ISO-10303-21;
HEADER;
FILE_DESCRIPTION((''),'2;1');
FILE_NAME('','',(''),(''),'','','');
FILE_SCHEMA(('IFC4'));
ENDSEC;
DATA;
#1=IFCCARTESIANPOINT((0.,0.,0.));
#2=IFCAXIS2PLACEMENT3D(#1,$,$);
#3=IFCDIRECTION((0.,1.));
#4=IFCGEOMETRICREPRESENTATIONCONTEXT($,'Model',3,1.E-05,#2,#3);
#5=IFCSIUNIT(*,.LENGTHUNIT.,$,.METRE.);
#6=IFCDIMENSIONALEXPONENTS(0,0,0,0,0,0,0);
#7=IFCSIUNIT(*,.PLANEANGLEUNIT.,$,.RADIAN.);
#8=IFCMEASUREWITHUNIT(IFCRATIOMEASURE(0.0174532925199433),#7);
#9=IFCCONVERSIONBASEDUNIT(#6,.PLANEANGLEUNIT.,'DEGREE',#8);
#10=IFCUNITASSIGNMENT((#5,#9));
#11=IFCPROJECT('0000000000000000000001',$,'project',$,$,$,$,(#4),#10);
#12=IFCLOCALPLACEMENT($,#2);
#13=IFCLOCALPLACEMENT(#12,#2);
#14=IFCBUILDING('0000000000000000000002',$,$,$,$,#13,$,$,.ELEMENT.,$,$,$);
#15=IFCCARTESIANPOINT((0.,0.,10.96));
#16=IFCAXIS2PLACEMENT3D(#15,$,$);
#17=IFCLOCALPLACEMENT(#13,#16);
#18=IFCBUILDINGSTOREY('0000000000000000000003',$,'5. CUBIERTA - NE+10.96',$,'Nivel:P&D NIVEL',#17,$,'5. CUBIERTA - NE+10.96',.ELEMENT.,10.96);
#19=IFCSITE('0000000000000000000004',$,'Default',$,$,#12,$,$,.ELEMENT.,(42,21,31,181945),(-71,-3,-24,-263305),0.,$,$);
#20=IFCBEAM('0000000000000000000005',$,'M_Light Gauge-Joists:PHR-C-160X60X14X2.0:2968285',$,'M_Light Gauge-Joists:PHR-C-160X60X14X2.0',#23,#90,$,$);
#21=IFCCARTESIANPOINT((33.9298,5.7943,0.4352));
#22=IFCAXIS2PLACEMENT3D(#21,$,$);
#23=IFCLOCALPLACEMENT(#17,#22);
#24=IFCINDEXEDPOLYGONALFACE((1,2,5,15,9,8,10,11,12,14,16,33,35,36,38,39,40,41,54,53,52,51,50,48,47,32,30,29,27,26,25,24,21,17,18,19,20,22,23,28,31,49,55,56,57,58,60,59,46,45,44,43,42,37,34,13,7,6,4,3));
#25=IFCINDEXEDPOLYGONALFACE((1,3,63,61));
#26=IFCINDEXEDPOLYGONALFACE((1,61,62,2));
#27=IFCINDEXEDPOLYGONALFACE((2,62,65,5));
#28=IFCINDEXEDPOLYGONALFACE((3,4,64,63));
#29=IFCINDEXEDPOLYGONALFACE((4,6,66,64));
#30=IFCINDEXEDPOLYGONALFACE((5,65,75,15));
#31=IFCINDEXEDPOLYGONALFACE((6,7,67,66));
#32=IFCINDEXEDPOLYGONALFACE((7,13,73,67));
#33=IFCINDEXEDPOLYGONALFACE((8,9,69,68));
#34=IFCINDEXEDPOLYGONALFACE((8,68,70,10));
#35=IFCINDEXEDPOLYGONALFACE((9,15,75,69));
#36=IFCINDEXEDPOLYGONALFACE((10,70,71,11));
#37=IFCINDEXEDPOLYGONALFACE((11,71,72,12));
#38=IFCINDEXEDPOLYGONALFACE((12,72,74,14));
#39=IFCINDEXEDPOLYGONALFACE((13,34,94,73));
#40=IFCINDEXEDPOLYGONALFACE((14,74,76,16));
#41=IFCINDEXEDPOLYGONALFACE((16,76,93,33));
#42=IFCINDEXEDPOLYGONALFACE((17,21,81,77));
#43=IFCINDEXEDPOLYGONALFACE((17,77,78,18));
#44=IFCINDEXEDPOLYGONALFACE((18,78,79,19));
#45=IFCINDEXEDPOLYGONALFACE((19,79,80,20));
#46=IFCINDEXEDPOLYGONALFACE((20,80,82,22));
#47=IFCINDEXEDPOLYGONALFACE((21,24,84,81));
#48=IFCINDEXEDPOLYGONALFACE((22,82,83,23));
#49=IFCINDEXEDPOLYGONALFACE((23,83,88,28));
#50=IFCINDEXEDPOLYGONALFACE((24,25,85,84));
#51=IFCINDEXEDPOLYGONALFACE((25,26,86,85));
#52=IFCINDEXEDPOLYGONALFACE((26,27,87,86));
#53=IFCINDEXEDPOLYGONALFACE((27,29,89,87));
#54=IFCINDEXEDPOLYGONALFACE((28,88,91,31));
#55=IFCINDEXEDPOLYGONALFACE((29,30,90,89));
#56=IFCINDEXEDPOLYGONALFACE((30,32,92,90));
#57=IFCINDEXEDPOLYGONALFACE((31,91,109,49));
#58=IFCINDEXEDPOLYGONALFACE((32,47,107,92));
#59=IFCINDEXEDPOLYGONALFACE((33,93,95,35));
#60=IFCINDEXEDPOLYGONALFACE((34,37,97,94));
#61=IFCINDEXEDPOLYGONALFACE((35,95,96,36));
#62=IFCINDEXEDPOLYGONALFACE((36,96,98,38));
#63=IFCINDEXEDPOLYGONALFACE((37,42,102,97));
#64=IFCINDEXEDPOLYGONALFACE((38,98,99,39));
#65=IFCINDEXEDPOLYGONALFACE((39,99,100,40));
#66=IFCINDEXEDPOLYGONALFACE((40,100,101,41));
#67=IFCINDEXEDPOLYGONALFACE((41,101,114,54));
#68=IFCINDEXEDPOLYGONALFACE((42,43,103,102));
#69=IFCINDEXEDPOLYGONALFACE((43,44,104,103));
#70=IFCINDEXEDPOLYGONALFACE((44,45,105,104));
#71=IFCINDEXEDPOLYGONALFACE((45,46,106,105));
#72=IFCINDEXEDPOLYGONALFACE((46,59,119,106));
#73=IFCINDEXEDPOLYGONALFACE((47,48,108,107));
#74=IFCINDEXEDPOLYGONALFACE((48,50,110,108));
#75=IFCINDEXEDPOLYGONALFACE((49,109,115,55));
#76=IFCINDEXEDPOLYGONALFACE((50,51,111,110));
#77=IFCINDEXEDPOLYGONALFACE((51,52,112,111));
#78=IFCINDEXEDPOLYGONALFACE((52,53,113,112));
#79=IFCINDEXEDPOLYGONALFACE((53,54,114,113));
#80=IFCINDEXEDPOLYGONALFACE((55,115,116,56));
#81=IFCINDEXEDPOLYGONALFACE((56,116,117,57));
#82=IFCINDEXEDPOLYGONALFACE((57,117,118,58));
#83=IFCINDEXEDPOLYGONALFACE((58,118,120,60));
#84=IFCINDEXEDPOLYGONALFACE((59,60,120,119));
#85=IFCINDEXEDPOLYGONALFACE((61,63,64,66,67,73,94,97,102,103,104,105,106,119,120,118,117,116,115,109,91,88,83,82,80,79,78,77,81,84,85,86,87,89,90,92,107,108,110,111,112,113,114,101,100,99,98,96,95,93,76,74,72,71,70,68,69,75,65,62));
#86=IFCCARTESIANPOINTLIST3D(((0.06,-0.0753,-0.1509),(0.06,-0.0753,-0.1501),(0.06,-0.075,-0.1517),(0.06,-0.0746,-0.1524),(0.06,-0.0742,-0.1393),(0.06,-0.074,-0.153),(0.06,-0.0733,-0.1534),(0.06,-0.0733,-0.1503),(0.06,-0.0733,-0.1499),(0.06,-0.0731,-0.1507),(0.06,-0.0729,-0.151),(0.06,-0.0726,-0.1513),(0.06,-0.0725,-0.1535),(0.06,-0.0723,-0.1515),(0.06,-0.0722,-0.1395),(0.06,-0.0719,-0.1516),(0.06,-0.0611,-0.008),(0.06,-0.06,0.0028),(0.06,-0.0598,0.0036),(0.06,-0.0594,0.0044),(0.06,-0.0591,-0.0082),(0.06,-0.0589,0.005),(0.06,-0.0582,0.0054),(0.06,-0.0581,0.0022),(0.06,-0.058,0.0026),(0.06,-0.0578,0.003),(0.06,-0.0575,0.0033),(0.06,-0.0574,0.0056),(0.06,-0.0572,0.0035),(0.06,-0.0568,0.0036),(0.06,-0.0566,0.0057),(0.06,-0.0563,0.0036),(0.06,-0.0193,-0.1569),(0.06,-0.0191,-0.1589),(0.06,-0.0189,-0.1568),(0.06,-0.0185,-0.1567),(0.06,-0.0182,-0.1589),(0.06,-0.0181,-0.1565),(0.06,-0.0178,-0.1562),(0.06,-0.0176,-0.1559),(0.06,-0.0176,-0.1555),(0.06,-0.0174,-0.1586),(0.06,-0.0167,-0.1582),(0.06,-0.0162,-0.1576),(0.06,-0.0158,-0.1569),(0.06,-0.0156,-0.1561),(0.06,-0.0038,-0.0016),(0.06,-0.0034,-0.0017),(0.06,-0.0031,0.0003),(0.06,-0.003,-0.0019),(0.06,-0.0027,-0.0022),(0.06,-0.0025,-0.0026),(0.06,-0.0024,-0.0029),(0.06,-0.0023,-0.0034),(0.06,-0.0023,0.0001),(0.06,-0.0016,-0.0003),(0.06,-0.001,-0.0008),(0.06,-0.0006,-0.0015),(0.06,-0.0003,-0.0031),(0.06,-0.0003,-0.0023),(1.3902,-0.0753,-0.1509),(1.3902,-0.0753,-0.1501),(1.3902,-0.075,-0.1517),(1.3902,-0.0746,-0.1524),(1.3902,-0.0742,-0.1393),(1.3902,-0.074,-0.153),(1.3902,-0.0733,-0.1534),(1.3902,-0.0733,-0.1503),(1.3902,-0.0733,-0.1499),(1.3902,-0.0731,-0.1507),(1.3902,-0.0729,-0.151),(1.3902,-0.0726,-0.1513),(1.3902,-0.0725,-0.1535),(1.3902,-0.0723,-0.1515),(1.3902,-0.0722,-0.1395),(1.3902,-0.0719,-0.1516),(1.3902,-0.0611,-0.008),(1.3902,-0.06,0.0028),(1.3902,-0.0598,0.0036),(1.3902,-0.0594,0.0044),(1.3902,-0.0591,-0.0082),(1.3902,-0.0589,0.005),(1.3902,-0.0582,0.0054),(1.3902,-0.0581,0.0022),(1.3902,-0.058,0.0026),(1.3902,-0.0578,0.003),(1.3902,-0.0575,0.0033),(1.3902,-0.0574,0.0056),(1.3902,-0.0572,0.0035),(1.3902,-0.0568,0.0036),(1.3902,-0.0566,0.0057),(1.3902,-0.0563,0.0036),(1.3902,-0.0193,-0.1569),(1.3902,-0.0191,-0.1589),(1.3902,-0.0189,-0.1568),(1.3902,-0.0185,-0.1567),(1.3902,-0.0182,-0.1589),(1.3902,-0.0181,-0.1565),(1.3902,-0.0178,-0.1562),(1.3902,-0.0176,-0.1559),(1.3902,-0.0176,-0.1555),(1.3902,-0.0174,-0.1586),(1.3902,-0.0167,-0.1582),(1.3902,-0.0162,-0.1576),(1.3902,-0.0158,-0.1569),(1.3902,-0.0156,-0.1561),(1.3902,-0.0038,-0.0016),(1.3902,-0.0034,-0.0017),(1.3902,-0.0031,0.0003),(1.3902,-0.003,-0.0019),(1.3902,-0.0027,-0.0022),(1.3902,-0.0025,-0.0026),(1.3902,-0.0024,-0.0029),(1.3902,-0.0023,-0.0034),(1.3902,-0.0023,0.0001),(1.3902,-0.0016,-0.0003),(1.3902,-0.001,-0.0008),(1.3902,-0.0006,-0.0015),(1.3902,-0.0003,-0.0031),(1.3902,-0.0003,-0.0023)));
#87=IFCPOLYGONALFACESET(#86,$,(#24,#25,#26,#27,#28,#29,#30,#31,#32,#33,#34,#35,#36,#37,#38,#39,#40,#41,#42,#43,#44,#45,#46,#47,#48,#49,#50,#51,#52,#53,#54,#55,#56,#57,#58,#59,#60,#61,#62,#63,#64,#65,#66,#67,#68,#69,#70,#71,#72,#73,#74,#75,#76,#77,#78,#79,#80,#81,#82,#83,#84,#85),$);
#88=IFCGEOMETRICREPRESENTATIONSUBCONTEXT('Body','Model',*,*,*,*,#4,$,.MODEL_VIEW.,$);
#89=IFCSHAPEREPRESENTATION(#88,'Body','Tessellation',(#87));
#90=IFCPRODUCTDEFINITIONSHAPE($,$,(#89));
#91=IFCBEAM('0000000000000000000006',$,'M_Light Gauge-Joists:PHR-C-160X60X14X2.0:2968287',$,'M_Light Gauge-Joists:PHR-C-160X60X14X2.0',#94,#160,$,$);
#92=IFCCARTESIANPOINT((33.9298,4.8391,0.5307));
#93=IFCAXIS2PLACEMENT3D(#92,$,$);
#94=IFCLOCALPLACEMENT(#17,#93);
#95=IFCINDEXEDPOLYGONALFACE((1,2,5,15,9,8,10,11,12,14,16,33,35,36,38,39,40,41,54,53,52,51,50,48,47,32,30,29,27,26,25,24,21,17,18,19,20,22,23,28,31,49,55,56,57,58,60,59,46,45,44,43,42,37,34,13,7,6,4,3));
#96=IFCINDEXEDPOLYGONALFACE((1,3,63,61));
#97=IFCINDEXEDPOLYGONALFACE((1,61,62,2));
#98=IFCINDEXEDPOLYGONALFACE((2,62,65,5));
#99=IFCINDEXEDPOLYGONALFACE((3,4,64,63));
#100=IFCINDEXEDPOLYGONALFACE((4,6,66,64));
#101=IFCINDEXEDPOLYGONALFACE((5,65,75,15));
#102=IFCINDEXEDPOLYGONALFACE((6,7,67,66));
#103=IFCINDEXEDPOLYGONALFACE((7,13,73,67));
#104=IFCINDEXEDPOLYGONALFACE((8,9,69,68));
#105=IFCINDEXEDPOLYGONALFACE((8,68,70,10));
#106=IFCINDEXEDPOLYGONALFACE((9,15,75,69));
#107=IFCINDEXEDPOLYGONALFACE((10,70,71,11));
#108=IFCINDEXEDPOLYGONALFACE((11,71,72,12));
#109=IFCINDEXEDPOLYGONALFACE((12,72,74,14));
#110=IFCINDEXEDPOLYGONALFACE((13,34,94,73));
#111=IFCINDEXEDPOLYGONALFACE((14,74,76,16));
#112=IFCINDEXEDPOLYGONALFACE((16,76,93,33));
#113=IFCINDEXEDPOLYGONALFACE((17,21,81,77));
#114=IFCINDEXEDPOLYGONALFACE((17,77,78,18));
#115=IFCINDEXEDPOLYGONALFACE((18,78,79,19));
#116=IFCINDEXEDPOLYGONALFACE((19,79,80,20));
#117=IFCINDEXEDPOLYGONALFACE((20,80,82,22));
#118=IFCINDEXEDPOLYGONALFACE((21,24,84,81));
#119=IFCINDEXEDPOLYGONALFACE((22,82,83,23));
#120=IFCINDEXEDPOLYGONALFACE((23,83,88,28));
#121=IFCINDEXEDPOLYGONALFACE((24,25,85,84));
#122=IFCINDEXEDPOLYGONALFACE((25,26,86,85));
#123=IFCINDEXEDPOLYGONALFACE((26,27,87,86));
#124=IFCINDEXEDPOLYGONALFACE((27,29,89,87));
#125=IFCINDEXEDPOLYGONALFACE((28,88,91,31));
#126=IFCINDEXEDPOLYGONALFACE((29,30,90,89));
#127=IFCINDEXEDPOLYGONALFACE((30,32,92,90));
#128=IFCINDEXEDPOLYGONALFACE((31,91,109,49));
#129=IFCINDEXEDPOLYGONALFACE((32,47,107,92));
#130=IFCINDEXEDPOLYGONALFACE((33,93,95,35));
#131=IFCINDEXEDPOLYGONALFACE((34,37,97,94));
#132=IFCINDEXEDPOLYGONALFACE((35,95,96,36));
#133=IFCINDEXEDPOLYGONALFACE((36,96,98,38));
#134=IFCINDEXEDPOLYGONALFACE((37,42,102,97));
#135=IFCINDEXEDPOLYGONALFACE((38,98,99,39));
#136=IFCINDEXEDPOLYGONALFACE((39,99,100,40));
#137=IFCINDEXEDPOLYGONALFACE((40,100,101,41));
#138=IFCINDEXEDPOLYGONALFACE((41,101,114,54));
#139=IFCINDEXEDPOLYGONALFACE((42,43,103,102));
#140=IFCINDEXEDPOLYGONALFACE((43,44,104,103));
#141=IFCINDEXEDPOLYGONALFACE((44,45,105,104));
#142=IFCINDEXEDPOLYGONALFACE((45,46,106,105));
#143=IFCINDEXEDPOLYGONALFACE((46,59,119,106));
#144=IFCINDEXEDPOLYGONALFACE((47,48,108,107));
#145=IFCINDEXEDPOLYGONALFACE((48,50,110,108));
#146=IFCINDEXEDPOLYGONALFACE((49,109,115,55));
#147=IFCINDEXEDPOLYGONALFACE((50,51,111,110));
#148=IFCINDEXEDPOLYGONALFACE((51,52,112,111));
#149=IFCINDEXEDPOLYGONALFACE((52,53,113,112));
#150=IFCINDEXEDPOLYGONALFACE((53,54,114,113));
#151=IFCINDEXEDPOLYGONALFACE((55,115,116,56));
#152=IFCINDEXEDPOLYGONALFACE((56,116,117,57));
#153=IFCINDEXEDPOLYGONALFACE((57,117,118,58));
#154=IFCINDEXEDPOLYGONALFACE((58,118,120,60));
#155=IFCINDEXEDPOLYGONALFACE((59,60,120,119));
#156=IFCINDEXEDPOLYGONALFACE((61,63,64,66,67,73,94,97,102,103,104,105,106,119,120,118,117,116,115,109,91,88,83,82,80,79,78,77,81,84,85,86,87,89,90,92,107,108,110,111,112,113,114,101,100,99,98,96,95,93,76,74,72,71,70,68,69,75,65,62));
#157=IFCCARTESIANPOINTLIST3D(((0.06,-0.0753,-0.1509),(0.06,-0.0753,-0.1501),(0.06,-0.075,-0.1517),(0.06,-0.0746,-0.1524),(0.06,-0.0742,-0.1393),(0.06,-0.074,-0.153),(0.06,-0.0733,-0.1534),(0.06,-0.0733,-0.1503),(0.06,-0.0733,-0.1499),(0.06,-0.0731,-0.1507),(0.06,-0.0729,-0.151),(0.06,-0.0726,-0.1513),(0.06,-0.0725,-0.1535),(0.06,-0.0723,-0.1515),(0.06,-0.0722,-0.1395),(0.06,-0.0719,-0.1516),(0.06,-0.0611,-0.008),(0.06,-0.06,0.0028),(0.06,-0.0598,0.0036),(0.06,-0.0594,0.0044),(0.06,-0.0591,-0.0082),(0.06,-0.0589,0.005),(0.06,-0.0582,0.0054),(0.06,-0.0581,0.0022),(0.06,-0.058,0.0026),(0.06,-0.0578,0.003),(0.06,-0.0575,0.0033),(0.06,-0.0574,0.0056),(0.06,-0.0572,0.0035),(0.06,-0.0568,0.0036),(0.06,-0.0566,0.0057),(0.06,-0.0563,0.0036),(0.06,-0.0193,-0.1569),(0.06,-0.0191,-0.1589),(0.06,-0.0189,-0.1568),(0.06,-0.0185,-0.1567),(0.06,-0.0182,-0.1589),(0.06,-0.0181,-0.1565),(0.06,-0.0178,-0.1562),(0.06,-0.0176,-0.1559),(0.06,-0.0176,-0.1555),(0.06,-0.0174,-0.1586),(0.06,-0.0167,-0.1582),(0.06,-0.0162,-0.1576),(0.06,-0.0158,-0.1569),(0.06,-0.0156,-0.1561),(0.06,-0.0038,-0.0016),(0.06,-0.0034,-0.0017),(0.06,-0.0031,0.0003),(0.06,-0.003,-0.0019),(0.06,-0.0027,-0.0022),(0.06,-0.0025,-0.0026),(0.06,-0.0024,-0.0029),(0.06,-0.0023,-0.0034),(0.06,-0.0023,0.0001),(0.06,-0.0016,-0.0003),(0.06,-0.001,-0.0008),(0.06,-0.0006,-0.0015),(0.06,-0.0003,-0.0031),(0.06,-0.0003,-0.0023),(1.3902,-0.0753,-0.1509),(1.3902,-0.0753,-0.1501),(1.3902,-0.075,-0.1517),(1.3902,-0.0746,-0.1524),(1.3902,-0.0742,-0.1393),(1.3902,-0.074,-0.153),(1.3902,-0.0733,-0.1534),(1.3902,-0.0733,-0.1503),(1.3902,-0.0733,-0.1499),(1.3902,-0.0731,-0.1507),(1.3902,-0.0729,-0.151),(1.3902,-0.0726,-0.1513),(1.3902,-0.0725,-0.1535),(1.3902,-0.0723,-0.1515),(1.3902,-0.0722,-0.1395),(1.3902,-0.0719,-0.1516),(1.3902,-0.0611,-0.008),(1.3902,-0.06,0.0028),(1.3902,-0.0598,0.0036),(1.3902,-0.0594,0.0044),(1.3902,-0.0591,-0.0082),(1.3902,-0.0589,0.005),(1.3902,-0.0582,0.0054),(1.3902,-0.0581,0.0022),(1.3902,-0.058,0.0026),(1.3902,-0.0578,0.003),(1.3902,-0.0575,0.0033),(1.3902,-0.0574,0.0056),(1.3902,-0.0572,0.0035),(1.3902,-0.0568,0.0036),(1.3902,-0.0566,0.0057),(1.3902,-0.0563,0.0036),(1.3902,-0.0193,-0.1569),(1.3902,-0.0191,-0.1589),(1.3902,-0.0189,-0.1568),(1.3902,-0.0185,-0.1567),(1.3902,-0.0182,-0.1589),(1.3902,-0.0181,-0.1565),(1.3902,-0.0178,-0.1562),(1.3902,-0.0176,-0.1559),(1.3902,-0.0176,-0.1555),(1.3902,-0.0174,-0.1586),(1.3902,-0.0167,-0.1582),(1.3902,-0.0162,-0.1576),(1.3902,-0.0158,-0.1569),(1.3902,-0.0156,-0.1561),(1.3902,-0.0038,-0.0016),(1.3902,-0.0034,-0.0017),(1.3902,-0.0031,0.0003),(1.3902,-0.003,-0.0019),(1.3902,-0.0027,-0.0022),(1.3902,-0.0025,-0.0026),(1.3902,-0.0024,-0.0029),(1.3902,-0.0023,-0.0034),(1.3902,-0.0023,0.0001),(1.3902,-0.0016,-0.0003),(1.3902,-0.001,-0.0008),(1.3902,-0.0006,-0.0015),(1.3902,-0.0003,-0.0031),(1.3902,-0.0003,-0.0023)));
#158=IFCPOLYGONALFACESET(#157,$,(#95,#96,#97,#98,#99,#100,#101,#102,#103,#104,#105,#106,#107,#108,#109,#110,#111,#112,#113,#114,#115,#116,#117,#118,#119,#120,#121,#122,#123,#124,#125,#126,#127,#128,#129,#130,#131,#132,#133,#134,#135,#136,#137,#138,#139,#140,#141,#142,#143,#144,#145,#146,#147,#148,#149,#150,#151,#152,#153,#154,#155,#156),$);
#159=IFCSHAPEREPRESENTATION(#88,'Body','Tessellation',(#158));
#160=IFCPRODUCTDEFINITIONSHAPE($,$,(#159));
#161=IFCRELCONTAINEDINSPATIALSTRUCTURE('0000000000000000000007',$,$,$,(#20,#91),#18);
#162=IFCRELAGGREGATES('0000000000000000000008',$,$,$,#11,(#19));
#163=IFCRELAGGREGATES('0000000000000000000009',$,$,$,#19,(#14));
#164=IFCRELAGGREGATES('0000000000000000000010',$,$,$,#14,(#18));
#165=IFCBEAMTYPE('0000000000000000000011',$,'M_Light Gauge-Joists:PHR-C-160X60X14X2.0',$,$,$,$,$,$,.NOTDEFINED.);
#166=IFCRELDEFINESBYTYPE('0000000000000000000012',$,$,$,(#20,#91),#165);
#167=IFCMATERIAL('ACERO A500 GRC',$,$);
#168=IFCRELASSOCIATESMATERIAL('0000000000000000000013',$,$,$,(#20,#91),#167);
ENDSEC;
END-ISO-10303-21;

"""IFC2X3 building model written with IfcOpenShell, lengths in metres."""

from ifc_helpers import new_model, entity, si_unit, converted_unit, direction, frame, frame_2d, origin, place, context, subcontext, project, spatial, polyline, circle_curve, parameter, trimmed, segment, composite_curve, outline, extrude, material, type_object, element, save


model = new_model("IFC2X3")

# Units and contexts
model_context = context("Model", 3, precision=1e-05, world=origin(), true_north=direction((0.0, 1.0)))
body_context = subcontext(model_context, "Body", "Model", "MODEL_VIEW")
ifc_project = project(units=[si_unit("LENGTHUNIT", "METRE"), converted_unit("PLANEANGLEUNIT", "DEGREE", entity("IfcRatioMeasure", 0.0174532925199433), si_unit("PLANEANGLEUNIT", "RADIAN"), dimensions=[0, 0, 0, 0, 0, 0, 0])], contexts=[model_context])

# Site, building, storey
site_placement = place(None, origin())
site = spatial("IfcSite", under=ifc_project, at=site_placement, Name="Default", CompositionType="ELEMENT", RefLatitude=(42, 21, 31, 181945), RefLongitude=(-71, -3, -24, -263305), RefElevation=0.0)
building_placement = place(site_placement, origin())
building = spatial("IfcBuilding", under=site, at=building_placement, CompositionType="ELEMENT")
storey_placement = place(building_placement, frame((0.0, 0.0, 10.96)))
storey = spatial("IfcBuildingStorey", under=building, at=storey_placement, Name="5. CUBIERTA - NE+10.96", ObjectType="Nivel:P&D NIVEL", LongName="5. CUBIERTA - NE+10.96", CompositionType="ELEMENT", Elevation=10.96)

# Beams
ifc_material_1 = material(Name="ACERO A500 GRC")
beam_type_1 = type_object("IfcBeamType", Name="M_Light Gauge-Joists:PHR-C-160X60X14X2.0", PredefinedType="NOTDEFINED")
beam_1_placement = place(storey_placement, frame((33.9298, 5.7943, 0.4352)))
element("IfcBeam", 1, at=beam_1_placement, inside=storey, type_object=beam_type_1, material=ifc_material_1, Name="M_Light Gauge-Joists:PHR-C-160X60X14X2.0:2968285", ObjectType="M_Light Gauge-Joists:PHR-C-160X60X14X2.0", context=body_context, shape_type="SweptSolid", body=[
    extrude(outline(composite_curve([segment(polyline([(-0.0768, -0.0358), (0.0768, -0.0358)]), True, "CONTINUOUS"), segment(trimmed(circle_curve(frame_2d((0.0768, -0.0326), x_axis=(0.0, -1.0)), 0.0032), [parameter(0.0)], [parameter(90.0)], True, "PARAMETER"), True, "CONTINUOUS"), segment(polyline([(0.08, -0.0326), (0.08, 0.021)]), True, "CONTINUOUS"), segment(trimmed(circle_curve(frame_2d((0.0768, 0.021), x_axis=(1.0, 0.0)), 0.0032), [parameter(0.0)], [parameter(90.0)], True, "PARAMETER"), True, "CONTINUOUS"), segment(polyline([(0.0768, 0.0242), (0.066, 0.0242)]), True, "CONTINUOUS"), segment(polyline([(0.066, 0.0242), (0.066, 0.0222)]), True, "CONTINUOUS"), segment(polyline([(0.066, 0.0222), (0.0764, 0.0222)]), True, "CONTINUOUS"), segment(trimmed(circle_curve(frame_2d((0.0764, 0.0206), x_axis=(0.0, 1.0)), 0.0016), [parameter(270.0)], [parameter(0.0)], True, "PARAMETER"), False, "CONTINUOUS"), segment(polyline([(0.078, 0.0206), (0.078, -0.0322)]), True, "CONTINUOUS"), segment(trimmed(circle_curve(frame_2d((0.0764, -0.0322), x_axis=(1.0, 0.0)), 0.0016), [parameter(270.0)], [parameter(0.0)], True, "PARAMETER"), False, "CONTINUOUS"), segment(polyline([(0.0764, -0.0338), (-0.0764, -0.0338)]), True, "CONTINUOUS"), segment(trimmed(circle_curve(frame_2d((-0.0764, -0.0322), x_axis=(0.0, -1.0)), 0.0016), [parameter(270.0)], [parameter(0.0)], True, "PARAMETER"), False, "CONTINUOUS"), segment(polyline([(-0.078, -0.0322), (-0.078, 0.0206)]), True, "CONTINUOUS"), segment(trimmed(circle_curve(frame_2d((-0.0764, 0.0206), x_axis=(-1.0, 0.0)), 0.0016), [parameter(270.0)], [parameter(0.0)], True, "PARAMETER"), False, "CONTINUOUS"), segment(polyline([(-0.0764, 0.0222), (-0.066, 0.0222)]), True, "CONTINUOUS"), segment(polyline([(-0.066, 0.0222), (-0.066, 0.0242)]), True, "CONTINUOUS"), segment(polyline([(-0.066, 0.0242), (-0.0768, 0.0242)]), True, "CONTINUOUS"), segment(trimmed(circle_curve(frame_2d((-0.0768, 0.021), x_axis=(0.0, 1.0)), 0.0032), [parameter(0.0)], [parameter(90.0)], True, "PARAMETER"), True, "CONTINUOUS"), segment(polyline([(-0.08, 0.021), (-0.08, -0.0326)]), True, "CONTINUOUS"), segment(trimmed(circle_curve(frame_2d((-0.0768, -0.0326), x_axis=(-1.0, 0.0)), 0.0032), [parameter(0.0)], [parameter(90.0)], True, "PARAMETER"), True, "CONTINUOUS")], self_intersect=False)), frame((0.06, -0.0436, -0.076), z_axis=(1.0, 0.0, 0.0), x_axis=(0.0, 0.099504, 0.995037)), (0.0, 0.0, 1.0), 1.3302),
])
beam_2_placement = place(storey_placement, frame((33.9298, 4.8391, 0.5307)))
element("IfcBeam", 2, at=beam_2_placement, inside=storey, type_object=beam_type_1, material=ifc_material_1, Name="M_Light Gauge-Joists:PHR-C-160X60X14X2.0:2968287", ObjectType="M_Light Gauge-Joists:PHR-C-160X60X14X2.0", context=body_context, shape_type="SweptSolid", body=[
    extrude(outline(composite_curve([segment(polyline([(-0.0768, -0.0358), (0.0768, -0.0358)]), True, "CONTINUOUS"), segment(trimmed(circle_curve(frame_2d((0.0768, -0.0326), x_axis=(0.0, -1.0)), 0.0032), [parameter(0.0)], [parameter(90.0)], True, "PARAMETER"), True, "CONTINUOUS"), segment(polyline([(0.08, -0.0326), (0.08, 0.021)]), True, "CONTINUOUS"), segment(trimmed(circle_curve(frame_2d((0.0768, 0.021), x_axis=(1.0, 0.0)), 0.0032), [parameter(0.0)], [parameter(90.0)], True, "PARAMETER"), True, "CONTINUOUS"), segment(polyline([(0.0768, 0.0242), (0.066, 0.0242)]), True, "CONTINUOUS"), segment(polyline([(0.066, 0.0242), (0.066, 0.0222)]), True, "CONTINUOUS"), segment(polyline([(0.066, 0.0222), (0.0764, 0.0222)]), True, "CONTINUOUS"), segment(trimmed(circle_curve(frame_2d((0.0764, 0.0206), x_axis=(0.0, 1.0)), 0.0016), [parameter(270.0)], [parameter(0.0)], True, "PARAMETER"), False, "CONTINUOUS"), segment(polyline([(0.078, 0.0206), (0.078, -0.0322)]), True, "CONTINUOUS"), segment(trimmed(circle_curve(frame_2d((0.0764, -0.0322), x_axis=(1.0, 0.0)), 0.0016), [parameter(270.0)], [parameter(0.0)], True, "PARAMETER"), False, "CONTINUOUS"), segment(polyline([(0.0764, -0.0338), (-0.0764, -0.0338)]), True, "CONTINUOUS"), segment(trimmed(circle_curve(frame_2d((-0.0764, -0.0322), x_axis=(0.0, -1.0)), 0.0016), [parameter(270.0)], [parameter(0.0)], True, "PARAMETER"), False, "CONTINUOUS"), segment(polyline([(-0.078, -0.0322), (-0.078, 0.0206)]), True, "CONTINUOUS"), segment(trimmed(circle_curve(frame_2d((-0.0764, 0.0206), x_axis=(-1.0, 0.0)), 0.0016), [parameter(270.0)], [parameter(0.0)], True, "PARAMETER"), False, "CONTINUOUS"), segment(polyline([(-0.0764, 0.0222), (-0.066, 0.0222)]), True, "CONTINUOUS"), segment(polyline([(-0.066, 0.0222), (-0.066, 0.0242)]), True, "CONTINUOUS"), segment(polyline([(-0.066, 0.0242), (-0.0768, 0.0242)]), True, "CONTINUOUS"), segment(trimmed(circle_curve(frame_2d((-0.0768, 0.021), x_axis=(0.0, 1.0)), 0.0032), [parameter(0.0)], [parameter(90.0)], True, "PARAMETER"), True, "CONTINUOUS"), segment(polyline([(-0.08, 0.021), (-0.08, -0.0326)]), True, "CONTINUOUS"), segment(trimmed(circle_curve(frame_2d((-0.0768, -0.0326), x_axis=(-1.0, 0.0)), 0.0032), [parameter(0.0)], [parameter(90.0)], True, "PARAMETER"), True, "CONTINUOUS")], self_intersect=False)), frame((0.06, -0.0436, -0.076), z_axis=(1.0, 0.0, 0.0), x_axis=(0.0, 0.099504, 0.995037)), (0.0, 0.0, 1.0), 1.3302),
])

save(model, "model.ifc")
